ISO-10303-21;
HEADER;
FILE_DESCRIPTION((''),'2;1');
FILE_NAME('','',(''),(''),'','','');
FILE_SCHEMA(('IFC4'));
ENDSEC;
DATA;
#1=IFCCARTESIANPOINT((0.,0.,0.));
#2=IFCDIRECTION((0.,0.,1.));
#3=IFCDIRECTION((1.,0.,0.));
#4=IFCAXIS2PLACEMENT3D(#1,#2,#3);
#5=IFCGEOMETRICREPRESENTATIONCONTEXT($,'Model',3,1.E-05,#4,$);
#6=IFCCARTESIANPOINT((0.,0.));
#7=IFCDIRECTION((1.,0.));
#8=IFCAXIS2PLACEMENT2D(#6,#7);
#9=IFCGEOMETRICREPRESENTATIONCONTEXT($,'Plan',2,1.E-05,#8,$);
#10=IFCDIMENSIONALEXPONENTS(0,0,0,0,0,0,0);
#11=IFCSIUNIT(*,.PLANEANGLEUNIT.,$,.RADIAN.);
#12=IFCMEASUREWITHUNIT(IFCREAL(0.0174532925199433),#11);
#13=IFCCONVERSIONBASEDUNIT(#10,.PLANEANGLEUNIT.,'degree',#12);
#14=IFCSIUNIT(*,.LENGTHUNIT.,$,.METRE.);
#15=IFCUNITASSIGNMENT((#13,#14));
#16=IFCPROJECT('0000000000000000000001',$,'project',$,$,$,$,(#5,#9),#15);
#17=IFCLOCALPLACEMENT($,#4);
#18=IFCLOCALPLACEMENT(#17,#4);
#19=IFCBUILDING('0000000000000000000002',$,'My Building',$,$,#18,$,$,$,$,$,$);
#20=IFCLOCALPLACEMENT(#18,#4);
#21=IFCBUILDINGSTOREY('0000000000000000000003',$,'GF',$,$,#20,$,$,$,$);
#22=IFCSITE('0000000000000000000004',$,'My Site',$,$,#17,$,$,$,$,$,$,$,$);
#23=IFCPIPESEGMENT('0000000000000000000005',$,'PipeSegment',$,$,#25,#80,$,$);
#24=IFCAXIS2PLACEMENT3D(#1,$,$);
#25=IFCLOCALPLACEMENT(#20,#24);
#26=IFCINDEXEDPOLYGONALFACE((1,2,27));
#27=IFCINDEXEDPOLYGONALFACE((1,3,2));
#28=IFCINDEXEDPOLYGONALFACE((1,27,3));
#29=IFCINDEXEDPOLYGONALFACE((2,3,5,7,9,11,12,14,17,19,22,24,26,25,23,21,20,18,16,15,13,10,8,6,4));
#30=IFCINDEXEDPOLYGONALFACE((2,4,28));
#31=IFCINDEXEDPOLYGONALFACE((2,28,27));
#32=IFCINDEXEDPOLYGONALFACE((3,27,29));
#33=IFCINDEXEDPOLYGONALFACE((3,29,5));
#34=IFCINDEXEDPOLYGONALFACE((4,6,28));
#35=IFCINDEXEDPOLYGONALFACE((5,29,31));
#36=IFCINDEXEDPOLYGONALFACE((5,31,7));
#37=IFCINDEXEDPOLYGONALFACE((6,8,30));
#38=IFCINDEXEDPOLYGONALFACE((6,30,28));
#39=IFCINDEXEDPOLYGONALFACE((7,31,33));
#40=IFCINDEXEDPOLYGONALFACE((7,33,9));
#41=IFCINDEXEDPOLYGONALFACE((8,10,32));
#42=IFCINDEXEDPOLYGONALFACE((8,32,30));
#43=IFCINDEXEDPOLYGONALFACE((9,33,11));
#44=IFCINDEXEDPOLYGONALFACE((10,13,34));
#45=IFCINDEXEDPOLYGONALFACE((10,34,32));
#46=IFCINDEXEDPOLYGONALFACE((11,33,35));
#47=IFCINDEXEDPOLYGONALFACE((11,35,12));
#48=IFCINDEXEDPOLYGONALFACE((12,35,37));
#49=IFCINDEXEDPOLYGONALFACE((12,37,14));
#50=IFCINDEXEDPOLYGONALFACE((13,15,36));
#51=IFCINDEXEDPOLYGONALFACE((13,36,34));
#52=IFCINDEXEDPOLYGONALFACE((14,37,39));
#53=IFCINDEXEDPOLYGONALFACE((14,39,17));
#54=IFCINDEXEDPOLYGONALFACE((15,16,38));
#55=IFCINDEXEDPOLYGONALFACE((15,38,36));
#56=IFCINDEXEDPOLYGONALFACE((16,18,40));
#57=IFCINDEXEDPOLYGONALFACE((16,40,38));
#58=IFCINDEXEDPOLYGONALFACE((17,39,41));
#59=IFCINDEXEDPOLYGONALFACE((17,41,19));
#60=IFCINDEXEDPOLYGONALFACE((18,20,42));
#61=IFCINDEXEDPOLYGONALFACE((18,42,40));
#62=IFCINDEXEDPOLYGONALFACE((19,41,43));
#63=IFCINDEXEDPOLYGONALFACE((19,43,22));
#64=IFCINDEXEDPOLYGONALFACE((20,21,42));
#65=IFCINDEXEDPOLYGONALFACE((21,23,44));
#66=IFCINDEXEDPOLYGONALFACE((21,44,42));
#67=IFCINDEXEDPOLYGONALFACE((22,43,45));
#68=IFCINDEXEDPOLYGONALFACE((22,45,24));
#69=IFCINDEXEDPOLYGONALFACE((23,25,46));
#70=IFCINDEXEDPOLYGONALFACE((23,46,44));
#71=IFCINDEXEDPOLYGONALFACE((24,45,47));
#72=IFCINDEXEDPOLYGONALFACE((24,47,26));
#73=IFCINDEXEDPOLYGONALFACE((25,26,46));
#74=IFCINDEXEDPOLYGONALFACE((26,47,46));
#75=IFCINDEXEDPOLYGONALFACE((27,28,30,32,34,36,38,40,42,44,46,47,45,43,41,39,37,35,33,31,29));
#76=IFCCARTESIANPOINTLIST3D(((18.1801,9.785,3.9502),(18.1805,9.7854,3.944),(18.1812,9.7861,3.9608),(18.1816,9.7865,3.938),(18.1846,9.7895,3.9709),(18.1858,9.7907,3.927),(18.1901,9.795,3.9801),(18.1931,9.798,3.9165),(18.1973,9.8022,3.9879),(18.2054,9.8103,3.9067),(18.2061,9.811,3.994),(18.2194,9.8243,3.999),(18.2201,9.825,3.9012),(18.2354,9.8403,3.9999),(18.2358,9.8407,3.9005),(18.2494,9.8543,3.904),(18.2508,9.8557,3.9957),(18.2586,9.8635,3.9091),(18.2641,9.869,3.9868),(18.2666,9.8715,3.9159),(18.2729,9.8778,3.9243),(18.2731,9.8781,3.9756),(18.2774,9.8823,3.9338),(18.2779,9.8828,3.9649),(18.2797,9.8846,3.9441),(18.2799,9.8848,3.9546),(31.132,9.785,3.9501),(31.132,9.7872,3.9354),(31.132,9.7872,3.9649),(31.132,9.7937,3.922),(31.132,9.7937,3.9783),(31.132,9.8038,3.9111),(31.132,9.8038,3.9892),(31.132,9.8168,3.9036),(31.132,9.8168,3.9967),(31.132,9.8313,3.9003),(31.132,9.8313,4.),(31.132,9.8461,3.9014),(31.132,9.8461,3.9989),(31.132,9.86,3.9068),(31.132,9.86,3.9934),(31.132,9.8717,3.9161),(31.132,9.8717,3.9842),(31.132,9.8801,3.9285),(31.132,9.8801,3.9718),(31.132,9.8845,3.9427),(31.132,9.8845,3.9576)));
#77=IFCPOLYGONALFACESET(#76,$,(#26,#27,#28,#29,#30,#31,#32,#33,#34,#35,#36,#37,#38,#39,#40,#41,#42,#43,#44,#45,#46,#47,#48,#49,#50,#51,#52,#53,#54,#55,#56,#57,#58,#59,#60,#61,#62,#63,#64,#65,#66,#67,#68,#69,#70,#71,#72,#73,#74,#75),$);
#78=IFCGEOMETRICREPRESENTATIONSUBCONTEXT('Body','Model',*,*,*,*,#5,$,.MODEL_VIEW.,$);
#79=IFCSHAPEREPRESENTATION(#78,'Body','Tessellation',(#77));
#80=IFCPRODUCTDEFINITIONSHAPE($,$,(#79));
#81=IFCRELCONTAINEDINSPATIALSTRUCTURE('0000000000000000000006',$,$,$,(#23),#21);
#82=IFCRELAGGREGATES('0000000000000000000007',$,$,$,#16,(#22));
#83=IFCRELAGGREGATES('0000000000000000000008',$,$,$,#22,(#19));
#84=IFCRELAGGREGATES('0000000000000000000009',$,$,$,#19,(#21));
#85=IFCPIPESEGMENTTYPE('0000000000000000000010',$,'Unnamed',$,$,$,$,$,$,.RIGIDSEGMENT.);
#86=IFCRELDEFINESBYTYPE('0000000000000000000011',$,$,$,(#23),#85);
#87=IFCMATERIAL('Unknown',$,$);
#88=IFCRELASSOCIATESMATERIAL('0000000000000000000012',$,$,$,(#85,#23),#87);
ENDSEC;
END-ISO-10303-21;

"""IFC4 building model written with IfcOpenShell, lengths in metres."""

from ifc_helpers import new_model, entity, si_unit, converted_unit, frame, origin_with_axes, origin_2d_with_axis, place, context, subcontext, project, spatial, circle, extrude, clip, halfspace, material, material_profile, profile_set, profile_usage, type_object, element, save


model = new_model("IFC4")

# Units and contexts
model_context = context("Model", 3, precision=1e-05, world=origin_with_axes())
plan_context = context("Plan", 2, precision=1e-05, world=origin_2d_with_axis())
body_context_1 = subcontext(model_context, "Body", "Model", "MODEL_VIEW")
ifc_project = project(units=[converted_unit("PLANEANGLEUNIT", "degree", entity("IfcReal", 0.0174532925199433), si_unit("PLANEANGLEUNIT", "RADIAN"), dimensions=[0, 0, 0, 0, 0, 0, 0]), si_unit("LENGTHUNIT", "METRE")], contexts=[model_context, plan_context])

# Site, building, storey
site_placement = place(None, origin_with_axes())
site = spatial("IfcSite", under=ifc_project, at=site_placement, Name="My Site")
building_placement = place(site_placement, origin_with_axes())
building = spatial("IfcBuilding", under=site, at=building_placement, Name="My Building")
storey_placement = place(building_placement, origin_with_axes())
storey = spatial("IfcBuildingStorey", under=building, at=storey_placement, Name="GF")

# Shared definitions
ifc_material = material(Name="Unknown")

# Pipe segment
ifc_material_profile_1 = material_profile(ifc_material, circle(Radius=0.05))
ifc_profile_set_1 = profile_set([ifc_material_profile_1])
ifc_profile_usage_1 = profile_usage(ifc_profile_set_1, cardinal=5)
pipe_segment_type = type_object("IfcPipeSegmentType", Name="Unnamed", PredefinedType="RIGIDSEGMENT", material=ifc_profile_set_1)
pipe_segment_placement = place(storey_placement, frame((31.132, 9.835, 3.9501), z_axis=(-1.0, -0.000001, 0.000001), x_axis=(0.000001, -1.0, 0.0)))
element("IfcPipeSegment", 1, at=pipe_segment_placement, inside=storey, type_object=pipe_segment_type, material=ifc_profile_usage_1, Name="PipeSegment", context=body_context_1, shape_type="Clipping", body=[
    clip(extrude(circle(Radius=0.05), origin_with_axes(), (0.0, 0.0, 1.0), 12.9519), halfspace(frame((0.05, -4.0, 12.9519), z_axis=(-0.707134, 0.0, 0.707079), x_axis=(0.0, 1.0, 0.0)), False)),
])

save(model, "model.ifc")
